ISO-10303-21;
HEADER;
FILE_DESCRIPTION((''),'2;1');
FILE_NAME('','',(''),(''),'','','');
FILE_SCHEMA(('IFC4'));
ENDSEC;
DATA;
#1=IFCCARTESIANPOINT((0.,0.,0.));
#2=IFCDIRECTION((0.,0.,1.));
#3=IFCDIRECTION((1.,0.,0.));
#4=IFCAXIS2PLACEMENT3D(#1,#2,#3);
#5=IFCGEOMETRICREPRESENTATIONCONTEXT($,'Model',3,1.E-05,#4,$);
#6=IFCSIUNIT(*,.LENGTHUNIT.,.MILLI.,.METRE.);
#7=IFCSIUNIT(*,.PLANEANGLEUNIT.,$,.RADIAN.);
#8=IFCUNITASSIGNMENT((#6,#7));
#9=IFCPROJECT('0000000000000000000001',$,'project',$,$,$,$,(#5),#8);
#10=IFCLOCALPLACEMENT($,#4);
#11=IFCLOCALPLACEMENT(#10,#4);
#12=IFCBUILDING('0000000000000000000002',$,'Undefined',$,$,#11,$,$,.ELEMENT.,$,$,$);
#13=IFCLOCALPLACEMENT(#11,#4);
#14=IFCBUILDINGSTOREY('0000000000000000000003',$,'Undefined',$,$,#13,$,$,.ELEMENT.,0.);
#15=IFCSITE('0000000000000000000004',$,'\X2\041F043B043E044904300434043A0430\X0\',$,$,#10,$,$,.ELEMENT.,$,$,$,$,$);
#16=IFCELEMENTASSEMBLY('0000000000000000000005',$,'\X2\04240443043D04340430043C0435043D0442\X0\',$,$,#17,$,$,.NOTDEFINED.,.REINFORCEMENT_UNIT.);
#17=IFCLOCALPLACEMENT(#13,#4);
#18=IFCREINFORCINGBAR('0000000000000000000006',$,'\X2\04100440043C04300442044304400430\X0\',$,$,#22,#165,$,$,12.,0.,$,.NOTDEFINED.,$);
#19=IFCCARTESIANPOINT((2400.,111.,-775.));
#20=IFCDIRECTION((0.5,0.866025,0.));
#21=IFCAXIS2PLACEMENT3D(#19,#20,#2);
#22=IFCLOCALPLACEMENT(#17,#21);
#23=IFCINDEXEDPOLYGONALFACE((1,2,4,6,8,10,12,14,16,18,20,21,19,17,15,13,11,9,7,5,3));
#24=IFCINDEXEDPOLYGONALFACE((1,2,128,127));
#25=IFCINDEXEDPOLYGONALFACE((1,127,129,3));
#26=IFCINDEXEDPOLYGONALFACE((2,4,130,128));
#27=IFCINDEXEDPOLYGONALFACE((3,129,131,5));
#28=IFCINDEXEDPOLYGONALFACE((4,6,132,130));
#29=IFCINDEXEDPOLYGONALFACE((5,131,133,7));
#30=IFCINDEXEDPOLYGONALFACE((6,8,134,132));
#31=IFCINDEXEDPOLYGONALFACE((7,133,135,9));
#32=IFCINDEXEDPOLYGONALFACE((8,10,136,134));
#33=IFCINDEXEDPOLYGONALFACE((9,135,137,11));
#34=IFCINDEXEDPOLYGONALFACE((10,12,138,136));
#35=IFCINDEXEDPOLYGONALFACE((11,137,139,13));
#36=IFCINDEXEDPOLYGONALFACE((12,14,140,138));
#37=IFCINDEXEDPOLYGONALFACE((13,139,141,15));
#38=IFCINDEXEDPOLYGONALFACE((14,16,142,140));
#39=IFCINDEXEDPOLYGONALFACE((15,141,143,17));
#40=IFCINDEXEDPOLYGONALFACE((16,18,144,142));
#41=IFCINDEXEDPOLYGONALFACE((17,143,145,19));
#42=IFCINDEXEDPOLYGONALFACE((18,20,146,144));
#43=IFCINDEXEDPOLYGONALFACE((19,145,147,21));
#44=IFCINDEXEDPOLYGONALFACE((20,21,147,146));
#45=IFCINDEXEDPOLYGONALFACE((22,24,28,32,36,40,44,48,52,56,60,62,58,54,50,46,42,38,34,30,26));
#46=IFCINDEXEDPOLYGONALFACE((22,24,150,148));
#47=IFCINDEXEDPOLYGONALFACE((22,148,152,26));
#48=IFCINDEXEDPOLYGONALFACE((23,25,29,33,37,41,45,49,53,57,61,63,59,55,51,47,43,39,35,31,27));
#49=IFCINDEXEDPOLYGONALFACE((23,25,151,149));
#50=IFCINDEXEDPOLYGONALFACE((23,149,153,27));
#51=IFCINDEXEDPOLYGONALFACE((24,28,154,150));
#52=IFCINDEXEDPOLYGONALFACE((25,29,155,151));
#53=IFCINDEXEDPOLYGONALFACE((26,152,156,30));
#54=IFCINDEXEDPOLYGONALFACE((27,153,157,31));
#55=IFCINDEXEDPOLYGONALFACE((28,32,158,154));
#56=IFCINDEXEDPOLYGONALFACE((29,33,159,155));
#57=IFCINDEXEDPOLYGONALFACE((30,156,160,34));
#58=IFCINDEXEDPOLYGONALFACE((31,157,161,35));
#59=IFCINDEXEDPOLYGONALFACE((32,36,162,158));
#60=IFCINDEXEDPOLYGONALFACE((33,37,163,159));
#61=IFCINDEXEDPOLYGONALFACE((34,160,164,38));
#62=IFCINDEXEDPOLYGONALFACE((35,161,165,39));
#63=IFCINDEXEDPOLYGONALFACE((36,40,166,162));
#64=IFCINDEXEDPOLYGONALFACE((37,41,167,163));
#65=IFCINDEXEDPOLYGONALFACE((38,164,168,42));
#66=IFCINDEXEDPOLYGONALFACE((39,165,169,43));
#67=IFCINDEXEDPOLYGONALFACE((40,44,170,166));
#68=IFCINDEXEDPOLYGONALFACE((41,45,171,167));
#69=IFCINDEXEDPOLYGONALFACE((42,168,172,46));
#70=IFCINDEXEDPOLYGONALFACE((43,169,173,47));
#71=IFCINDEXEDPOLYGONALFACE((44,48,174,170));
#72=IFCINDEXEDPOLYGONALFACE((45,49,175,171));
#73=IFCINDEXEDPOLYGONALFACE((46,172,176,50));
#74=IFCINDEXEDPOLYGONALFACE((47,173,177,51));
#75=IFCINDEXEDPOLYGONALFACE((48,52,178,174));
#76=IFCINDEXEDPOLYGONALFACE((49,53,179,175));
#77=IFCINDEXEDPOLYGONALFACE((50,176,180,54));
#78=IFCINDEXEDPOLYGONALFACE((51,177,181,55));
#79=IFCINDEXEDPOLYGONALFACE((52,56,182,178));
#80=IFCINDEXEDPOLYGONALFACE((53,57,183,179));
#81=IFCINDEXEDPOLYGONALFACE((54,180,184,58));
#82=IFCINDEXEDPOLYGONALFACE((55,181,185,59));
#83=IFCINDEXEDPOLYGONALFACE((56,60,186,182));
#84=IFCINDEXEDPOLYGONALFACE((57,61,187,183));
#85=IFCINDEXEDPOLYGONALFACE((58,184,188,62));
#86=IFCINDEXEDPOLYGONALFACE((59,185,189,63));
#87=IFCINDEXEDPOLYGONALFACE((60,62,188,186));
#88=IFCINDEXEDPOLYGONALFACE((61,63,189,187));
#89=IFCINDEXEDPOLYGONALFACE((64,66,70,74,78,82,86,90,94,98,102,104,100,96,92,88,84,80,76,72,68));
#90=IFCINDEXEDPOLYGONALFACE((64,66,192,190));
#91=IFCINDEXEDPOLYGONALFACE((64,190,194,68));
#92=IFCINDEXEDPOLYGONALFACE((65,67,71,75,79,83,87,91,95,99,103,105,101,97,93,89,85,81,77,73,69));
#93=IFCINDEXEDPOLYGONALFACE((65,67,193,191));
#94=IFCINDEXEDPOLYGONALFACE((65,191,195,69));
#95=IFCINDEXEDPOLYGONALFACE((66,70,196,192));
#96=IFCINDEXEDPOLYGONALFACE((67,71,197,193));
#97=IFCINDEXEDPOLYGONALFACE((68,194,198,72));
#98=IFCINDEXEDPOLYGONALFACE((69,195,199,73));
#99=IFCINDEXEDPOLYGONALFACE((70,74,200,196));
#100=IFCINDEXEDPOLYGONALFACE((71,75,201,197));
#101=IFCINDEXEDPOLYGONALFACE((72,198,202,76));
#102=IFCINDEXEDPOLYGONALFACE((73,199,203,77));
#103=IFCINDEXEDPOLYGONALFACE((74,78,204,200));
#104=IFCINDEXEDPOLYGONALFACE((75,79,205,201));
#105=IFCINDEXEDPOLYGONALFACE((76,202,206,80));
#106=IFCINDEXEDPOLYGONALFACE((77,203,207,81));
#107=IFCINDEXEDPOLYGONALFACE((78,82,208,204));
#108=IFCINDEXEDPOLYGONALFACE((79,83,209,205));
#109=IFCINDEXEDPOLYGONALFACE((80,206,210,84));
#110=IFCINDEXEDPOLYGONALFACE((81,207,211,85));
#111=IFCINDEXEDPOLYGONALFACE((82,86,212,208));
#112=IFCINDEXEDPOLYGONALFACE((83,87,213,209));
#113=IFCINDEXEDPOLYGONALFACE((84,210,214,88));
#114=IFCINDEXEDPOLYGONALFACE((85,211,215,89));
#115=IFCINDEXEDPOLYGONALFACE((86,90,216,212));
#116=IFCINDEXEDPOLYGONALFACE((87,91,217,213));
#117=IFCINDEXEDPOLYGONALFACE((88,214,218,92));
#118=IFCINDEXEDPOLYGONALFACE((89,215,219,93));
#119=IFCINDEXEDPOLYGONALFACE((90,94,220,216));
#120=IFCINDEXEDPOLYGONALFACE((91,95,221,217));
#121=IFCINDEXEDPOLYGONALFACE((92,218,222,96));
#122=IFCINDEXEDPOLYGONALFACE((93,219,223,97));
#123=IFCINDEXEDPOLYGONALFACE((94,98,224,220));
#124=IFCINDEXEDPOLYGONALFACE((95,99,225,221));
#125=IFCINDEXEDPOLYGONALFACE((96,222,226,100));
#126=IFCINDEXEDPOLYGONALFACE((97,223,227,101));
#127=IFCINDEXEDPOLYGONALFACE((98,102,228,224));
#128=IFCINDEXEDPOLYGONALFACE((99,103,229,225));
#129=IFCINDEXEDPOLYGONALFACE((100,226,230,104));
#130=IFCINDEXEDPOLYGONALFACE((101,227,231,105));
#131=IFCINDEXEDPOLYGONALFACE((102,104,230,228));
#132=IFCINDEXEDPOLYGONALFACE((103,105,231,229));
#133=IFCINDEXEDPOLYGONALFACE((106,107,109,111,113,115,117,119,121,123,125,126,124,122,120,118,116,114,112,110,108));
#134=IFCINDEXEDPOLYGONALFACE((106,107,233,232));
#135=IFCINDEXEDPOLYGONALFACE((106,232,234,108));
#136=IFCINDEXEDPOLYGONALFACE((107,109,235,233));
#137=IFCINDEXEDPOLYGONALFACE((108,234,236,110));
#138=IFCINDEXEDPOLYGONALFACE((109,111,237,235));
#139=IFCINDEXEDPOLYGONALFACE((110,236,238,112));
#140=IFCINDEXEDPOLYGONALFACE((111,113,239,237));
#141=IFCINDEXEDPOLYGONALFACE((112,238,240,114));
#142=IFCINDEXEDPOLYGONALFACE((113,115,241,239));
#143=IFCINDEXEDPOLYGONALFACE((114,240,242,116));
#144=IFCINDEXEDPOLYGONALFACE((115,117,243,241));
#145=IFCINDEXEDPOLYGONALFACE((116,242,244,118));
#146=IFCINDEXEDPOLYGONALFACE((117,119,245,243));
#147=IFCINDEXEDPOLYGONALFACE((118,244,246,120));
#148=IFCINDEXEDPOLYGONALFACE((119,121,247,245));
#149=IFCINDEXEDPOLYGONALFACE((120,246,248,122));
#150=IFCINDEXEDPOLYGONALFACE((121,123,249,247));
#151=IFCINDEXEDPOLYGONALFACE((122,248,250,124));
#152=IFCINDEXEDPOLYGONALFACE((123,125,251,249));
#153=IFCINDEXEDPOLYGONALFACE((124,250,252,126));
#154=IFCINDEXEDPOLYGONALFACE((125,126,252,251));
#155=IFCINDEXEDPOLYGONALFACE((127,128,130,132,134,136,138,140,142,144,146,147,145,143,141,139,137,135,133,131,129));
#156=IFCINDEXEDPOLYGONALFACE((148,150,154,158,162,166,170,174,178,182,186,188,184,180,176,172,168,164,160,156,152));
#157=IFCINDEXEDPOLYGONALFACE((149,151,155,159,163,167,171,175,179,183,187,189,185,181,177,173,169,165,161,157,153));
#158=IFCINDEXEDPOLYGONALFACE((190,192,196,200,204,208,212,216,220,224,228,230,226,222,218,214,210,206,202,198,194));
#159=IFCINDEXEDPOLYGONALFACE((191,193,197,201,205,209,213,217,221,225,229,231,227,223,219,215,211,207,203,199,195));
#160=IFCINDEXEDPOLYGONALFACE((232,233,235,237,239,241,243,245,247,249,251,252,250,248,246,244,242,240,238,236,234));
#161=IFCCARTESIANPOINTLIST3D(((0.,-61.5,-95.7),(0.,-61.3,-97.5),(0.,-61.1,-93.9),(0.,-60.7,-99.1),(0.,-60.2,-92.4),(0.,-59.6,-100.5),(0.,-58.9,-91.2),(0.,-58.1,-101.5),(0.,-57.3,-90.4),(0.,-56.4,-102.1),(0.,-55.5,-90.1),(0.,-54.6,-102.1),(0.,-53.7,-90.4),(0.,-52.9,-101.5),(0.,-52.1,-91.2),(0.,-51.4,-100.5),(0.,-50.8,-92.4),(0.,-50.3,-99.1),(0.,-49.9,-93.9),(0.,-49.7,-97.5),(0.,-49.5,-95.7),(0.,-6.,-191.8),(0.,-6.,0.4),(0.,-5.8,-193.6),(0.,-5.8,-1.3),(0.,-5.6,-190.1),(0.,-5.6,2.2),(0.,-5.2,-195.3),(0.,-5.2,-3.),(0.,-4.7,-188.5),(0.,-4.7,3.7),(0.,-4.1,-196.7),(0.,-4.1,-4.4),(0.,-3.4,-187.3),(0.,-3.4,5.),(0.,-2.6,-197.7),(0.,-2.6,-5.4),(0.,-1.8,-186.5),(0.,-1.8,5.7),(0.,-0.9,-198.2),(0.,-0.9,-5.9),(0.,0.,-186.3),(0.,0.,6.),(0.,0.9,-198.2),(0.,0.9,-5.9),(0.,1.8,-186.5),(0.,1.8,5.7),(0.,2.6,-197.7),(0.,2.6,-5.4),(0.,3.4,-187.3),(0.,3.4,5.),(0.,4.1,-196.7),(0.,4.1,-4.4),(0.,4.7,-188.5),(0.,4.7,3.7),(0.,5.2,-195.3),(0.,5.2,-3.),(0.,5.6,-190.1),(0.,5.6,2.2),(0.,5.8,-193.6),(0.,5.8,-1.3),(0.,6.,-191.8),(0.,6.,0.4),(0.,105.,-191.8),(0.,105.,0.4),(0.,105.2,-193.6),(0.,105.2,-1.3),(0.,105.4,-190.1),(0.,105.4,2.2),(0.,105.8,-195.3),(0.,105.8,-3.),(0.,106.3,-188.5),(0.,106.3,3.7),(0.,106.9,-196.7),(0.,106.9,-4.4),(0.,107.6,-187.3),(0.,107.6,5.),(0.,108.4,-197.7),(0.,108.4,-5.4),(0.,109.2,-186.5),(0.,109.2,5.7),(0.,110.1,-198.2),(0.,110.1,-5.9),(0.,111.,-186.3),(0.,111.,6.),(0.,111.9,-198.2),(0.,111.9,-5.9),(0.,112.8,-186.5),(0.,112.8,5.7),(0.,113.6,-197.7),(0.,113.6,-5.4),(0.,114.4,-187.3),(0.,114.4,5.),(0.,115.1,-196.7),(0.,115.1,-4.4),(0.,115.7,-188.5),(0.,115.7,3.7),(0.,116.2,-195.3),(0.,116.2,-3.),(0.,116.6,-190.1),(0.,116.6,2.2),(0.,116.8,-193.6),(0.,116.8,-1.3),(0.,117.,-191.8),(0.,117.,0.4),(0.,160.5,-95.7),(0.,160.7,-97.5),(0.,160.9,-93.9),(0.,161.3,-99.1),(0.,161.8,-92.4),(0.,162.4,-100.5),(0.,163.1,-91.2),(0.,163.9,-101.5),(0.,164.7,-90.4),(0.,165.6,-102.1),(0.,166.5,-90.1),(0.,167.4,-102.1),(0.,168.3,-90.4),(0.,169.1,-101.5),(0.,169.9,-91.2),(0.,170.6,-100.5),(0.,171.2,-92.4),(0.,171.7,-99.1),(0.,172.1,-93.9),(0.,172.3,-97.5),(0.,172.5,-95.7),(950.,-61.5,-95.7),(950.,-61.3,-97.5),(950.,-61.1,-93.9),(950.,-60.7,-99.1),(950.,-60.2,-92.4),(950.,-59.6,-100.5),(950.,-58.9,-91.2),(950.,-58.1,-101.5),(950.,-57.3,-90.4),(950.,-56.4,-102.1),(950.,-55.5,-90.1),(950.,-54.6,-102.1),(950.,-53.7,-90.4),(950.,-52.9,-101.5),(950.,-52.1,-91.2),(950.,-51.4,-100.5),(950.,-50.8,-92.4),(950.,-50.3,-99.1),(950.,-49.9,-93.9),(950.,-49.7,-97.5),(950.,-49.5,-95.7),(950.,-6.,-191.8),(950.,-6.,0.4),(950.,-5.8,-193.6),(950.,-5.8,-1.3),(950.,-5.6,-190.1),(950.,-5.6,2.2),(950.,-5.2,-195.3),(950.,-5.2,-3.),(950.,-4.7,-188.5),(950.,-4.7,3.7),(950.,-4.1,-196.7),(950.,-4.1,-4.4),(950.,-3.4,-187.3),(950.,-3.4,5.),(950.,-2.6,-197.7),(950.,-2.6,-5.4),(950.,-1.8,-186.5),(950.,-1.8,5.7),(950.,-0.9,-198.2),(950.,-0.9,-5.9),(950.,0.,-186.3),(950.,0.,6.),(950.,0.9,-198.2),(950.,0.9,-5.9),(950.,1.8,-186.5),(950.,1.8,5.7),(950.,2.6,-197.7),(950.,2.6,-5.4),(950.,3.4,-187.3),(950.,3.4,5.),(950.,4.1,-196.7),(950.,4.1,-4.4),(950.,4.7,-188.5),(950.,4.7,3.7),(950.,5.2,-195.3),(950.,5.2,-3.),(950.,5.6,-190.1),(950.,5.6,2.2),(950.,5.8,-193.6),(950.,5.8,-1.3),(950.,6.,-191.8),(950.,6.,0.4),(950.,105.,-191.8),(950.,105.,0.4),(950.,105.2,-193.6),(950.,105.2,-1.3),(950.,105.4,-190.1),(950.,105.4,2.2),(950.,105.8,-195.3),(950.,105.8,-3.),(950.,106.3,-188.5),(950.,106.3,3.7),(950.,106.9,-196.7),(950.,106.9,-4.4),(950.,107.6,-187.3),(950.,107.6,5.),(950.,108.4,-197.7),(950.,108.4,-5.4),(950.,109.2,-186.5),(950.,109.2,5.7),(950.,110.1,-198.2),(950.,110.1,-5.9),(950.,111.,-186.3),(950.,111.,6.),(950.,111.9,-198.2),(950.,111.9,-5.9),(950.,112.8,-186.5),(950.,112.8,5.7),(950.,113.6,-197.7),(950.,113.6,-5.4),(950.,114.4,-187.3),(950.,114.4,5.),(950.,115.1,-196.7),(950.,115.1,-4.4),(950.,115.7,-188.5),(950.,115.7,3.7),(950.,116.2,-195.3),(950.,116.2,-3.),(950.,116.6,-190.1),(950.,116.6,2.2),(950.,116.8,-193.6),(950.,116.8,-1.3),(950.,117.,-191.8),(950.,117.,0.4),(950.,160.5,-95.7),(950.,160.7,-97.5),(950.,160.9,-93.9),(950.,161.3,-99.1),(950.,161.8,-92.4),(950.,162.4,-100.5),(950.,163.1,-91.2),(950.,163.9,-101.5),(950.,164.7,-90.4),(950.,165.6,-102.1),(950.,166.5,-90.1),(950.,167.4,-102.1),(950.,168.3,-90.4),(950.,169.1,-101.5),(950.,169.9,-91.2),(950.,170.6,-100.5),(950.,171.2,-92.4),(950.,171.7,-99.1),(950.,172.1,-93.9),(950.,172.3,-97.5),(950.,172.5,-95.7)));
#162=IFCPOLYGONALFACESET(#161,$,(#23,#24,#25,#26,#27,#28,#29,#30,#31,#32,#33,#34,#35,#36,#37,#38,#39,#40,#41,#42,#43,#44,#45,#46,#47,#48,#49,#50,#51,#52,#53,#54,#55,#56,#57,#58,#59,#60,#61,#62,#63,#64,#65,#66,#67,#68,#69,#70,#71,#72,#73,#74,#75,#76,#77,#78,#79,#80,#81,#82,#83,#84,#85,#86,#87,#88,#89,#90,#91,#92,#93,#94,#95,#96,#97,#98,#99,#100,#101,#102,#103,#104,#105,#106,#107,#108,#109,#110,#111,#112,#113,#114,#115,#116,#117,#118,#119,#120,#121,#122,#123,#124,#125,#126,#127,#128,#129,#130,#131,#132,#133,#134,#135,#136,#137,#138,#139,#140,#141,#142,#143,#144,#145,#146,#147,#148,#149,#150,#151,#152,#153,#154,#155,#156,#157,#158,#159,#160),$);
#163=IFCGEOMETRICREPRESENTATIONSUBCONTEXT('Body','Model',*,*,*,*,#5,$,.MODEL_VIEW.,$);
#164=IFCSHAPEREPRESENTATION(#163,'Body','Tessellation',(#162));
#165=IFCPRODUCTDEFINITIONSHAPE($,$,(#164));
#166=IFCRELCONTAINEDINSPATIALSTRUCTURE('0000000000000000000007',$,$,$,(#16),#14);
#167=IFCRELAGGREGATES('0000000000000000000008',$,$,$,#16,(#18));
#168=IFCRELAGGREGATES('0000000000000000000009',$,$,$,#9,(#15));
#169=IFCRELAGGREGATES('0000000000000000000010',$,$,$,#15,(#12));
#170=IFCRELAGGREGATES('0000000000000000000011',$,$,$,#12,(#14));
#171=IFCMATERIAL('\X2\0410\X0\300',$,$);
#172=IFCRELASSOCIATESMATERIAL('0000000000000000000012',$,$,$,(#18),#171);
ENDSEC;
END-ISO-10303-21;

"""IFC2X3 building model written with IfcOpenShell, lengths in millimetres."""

from ifc_helpers import new_model, entity, si_unit, frame, origin_with_axes, place, context, subcontext, project, spatial, source, transform, mapped, material, element, aggregate, save


model = new_model("IFC2X3")

# Units and contexts
model_context = context("Model", 3, precision=1e-05, world=origin_with_axes())
body_context = subcontext(model_context, "Body", "Model", "MODEL_VIEW")
ifc_project = project(units=[si_unit("LENGTHUNIT", "METRE", prefix="MILLI"), si_unit("PLANEANGLEUNIT", "RADIAN")], contexts=[model_context])

# Site, building, storey
site_placement = place(None, origin_with_axes())
site = spatial("IfcSite", under=ifc_project, at=site_placement, Name="Площадка", CompositionType="ELEMENT")
building_placement = place(site_placement, origin_with_axes())
building = spatial("IfcBuilding", under=site, at=building_placement, Name="Undefined", CompositionType="ELEMENT")
storey_placement = place(building_placement, origin_with_axes())
storey = spatial("IfcBuildingStorey", under=building, at=storey_placement, Name="Undefined", CompositionType="ELEMENT", Elevation=0.0)

# Element assembly
assembly_1_placement = place(storey_placement, origin_with_axes())
assembly_1 = element("IfcElementAssembly", 1, at=assembly_1_placement, inside=storey, Name="Фундамент", AssemblyPlace="NOTDEFINED", PredefinedType="REINFORCEMENT_UNIT")

# Reinforcing bar
ifc_material_1 = material(Name="А300")
shared_shape_1 = source(origin_with_axes(), body_context, "Body", "AdvancedSweptSolid", [
    entity("IfcSweptDiskSolid", entity("IfcTrimmedCurve", entity("IfcLine", entity("IfcCartesianPoint", [0.0, 0.0, 0.0]), entity("IfcVector", entity("IfcDirection", [1.0, 0.0, 0.0]), 1.0)), [entity("IfcParameterValue", 0.0)], [entity("IfcParameterValue", 950.0)], True, "PARAMETER"), 6.0, None, 0.0, 950.0),
])
shared_shape_2 = source(origin_with_axes(), body_context, "Body", "AdvancedSweptSolid", [
    entity("IfcSweptDiskSolid", entity("IfcTrimmedCurve", entity("IfcLine", entity("IfcCartesianPoint", [0.0, 0.0, 0.0]), entity("IfcVector", entity("IfcDirection", [1.0, 0.0, 0.0]), 1.0)), [entity("IfcParameterValue", 0.0)], [entity("IfcParameterValue", 950.0)], True, "PARAMETER"), 6.0, None, 0.0, 950.0),
])
shared_shape_3 = source(origin_with_axes(), body_context, "Body", "AdvancedSweptSolid", [
    entity("IfcSweptDiskSolid", entity("IfcTrimmedCurve", entity("IfcLine", entity("IfcCartesianPoint", [0.0, 0.0, 0.0]), entity("IfcVector", entity("IfcDirection", [1.0, 0.0, 0.0]), 1.0)), [entity("IfcParameterValue", 0.0)], [entity("IfcParameterValue", 950.0)], True, "PARAMETER"), 6.0, None, 0.0, 950.0),
])
shared_shape_4 = source(origin_with_axes(), body_context, "Body", "AdvancedSweptSolid", [
    entity("IfcSweptDiskSolid", entity("IfcTrimmedCurve", entity("IfcLine", entity("IfcCartesianPoint", [0.0, 0.0, 0.0]), entity("IfcVector", entity("IfcDirection", [1.0, 0.0, 0.0]), 1.0)), [entity("IfcParameterValue", 0.0)], [entity("IfcParameterValue", 950.0)], True, "PARAMETER"), 6.0, None, 0.0, 950.0),
])
shared_shape_5 = source(origin_with_axes(), body_context, "Body", "AdvancedSweptSolid", [
    entity("IfcSweptDiskSolid", entity("IfcTrimmedCurve", entity("IfcLine", entity("IfcCartesianPoint", [0.0, 0.0, 0.0]), entity("IfcVector", entity("IfcDirection", [1.0, 0.0, 0.0]), 1.0)), [entity("IfcParameterValue", 0.0)], [entity("IfcParameterValue", 950.0)], True, "PARAMETER"), 6.0, None, 0.0, 950.0),
])
shared_shape_6 = source(origin_with_axes(), body_context, "Body", "AdvancedSweptSolid", [
    entity("IfcSweptDiskSolid", entity("IfcTrimmedCurve", entity("IfcLine", entity("IfcCartesianPoint", [0.0, 0.0, 0.0]), entity("IfcVector", entity("IfcDirection", [1.0, 0.0, 0.0]), 1.0)), [entity("IfcParameterValue", 0.0)], [entity("IfcParameterValue", 950.0)], True, "PARAMETER"), 6.0, None, 0.0, 950.0),
])
reinforcing_bar_1_placement = place(assembly_1_placement, frame((2400.0, 111.0, -775.0), z_axis=(0.5, 0.866025, 0.0), x_axis=(0.0, 0.0, 1.0)))
reinforcing_bar_1 = element("IfcReinforcingBar", 2, at=reinforcing_bar_1_placement, material=ifc_material_1, Name="Арматура", BarRole="NOTDEFINED", CrossSectionArea=0.0, NominalDiameter=12.0, context=body_context, shape_type="MappedRepresentation", body=[
    mapped(shared_shape_1, transform((0.0, 0.0, 0.0))),
    mapped(shared_shape_2, transform((0.0, -55.5, -96.1))),
    mapped(shared_shape_3, transform((0.0, 0.0, -192.3))),
    mapped(shared_shape_4, transform((0.0, 111.0, -192.3))),
    mapped(shared_shape_5, transform((0.0, 166.5, -96.1))),
    mapped(shared_shape_6, transform((0.0, 111.0, 0.0))),
])
aggregate(assembly_1, [reinforcing_bar_1])

save(model, "model.ifc")
